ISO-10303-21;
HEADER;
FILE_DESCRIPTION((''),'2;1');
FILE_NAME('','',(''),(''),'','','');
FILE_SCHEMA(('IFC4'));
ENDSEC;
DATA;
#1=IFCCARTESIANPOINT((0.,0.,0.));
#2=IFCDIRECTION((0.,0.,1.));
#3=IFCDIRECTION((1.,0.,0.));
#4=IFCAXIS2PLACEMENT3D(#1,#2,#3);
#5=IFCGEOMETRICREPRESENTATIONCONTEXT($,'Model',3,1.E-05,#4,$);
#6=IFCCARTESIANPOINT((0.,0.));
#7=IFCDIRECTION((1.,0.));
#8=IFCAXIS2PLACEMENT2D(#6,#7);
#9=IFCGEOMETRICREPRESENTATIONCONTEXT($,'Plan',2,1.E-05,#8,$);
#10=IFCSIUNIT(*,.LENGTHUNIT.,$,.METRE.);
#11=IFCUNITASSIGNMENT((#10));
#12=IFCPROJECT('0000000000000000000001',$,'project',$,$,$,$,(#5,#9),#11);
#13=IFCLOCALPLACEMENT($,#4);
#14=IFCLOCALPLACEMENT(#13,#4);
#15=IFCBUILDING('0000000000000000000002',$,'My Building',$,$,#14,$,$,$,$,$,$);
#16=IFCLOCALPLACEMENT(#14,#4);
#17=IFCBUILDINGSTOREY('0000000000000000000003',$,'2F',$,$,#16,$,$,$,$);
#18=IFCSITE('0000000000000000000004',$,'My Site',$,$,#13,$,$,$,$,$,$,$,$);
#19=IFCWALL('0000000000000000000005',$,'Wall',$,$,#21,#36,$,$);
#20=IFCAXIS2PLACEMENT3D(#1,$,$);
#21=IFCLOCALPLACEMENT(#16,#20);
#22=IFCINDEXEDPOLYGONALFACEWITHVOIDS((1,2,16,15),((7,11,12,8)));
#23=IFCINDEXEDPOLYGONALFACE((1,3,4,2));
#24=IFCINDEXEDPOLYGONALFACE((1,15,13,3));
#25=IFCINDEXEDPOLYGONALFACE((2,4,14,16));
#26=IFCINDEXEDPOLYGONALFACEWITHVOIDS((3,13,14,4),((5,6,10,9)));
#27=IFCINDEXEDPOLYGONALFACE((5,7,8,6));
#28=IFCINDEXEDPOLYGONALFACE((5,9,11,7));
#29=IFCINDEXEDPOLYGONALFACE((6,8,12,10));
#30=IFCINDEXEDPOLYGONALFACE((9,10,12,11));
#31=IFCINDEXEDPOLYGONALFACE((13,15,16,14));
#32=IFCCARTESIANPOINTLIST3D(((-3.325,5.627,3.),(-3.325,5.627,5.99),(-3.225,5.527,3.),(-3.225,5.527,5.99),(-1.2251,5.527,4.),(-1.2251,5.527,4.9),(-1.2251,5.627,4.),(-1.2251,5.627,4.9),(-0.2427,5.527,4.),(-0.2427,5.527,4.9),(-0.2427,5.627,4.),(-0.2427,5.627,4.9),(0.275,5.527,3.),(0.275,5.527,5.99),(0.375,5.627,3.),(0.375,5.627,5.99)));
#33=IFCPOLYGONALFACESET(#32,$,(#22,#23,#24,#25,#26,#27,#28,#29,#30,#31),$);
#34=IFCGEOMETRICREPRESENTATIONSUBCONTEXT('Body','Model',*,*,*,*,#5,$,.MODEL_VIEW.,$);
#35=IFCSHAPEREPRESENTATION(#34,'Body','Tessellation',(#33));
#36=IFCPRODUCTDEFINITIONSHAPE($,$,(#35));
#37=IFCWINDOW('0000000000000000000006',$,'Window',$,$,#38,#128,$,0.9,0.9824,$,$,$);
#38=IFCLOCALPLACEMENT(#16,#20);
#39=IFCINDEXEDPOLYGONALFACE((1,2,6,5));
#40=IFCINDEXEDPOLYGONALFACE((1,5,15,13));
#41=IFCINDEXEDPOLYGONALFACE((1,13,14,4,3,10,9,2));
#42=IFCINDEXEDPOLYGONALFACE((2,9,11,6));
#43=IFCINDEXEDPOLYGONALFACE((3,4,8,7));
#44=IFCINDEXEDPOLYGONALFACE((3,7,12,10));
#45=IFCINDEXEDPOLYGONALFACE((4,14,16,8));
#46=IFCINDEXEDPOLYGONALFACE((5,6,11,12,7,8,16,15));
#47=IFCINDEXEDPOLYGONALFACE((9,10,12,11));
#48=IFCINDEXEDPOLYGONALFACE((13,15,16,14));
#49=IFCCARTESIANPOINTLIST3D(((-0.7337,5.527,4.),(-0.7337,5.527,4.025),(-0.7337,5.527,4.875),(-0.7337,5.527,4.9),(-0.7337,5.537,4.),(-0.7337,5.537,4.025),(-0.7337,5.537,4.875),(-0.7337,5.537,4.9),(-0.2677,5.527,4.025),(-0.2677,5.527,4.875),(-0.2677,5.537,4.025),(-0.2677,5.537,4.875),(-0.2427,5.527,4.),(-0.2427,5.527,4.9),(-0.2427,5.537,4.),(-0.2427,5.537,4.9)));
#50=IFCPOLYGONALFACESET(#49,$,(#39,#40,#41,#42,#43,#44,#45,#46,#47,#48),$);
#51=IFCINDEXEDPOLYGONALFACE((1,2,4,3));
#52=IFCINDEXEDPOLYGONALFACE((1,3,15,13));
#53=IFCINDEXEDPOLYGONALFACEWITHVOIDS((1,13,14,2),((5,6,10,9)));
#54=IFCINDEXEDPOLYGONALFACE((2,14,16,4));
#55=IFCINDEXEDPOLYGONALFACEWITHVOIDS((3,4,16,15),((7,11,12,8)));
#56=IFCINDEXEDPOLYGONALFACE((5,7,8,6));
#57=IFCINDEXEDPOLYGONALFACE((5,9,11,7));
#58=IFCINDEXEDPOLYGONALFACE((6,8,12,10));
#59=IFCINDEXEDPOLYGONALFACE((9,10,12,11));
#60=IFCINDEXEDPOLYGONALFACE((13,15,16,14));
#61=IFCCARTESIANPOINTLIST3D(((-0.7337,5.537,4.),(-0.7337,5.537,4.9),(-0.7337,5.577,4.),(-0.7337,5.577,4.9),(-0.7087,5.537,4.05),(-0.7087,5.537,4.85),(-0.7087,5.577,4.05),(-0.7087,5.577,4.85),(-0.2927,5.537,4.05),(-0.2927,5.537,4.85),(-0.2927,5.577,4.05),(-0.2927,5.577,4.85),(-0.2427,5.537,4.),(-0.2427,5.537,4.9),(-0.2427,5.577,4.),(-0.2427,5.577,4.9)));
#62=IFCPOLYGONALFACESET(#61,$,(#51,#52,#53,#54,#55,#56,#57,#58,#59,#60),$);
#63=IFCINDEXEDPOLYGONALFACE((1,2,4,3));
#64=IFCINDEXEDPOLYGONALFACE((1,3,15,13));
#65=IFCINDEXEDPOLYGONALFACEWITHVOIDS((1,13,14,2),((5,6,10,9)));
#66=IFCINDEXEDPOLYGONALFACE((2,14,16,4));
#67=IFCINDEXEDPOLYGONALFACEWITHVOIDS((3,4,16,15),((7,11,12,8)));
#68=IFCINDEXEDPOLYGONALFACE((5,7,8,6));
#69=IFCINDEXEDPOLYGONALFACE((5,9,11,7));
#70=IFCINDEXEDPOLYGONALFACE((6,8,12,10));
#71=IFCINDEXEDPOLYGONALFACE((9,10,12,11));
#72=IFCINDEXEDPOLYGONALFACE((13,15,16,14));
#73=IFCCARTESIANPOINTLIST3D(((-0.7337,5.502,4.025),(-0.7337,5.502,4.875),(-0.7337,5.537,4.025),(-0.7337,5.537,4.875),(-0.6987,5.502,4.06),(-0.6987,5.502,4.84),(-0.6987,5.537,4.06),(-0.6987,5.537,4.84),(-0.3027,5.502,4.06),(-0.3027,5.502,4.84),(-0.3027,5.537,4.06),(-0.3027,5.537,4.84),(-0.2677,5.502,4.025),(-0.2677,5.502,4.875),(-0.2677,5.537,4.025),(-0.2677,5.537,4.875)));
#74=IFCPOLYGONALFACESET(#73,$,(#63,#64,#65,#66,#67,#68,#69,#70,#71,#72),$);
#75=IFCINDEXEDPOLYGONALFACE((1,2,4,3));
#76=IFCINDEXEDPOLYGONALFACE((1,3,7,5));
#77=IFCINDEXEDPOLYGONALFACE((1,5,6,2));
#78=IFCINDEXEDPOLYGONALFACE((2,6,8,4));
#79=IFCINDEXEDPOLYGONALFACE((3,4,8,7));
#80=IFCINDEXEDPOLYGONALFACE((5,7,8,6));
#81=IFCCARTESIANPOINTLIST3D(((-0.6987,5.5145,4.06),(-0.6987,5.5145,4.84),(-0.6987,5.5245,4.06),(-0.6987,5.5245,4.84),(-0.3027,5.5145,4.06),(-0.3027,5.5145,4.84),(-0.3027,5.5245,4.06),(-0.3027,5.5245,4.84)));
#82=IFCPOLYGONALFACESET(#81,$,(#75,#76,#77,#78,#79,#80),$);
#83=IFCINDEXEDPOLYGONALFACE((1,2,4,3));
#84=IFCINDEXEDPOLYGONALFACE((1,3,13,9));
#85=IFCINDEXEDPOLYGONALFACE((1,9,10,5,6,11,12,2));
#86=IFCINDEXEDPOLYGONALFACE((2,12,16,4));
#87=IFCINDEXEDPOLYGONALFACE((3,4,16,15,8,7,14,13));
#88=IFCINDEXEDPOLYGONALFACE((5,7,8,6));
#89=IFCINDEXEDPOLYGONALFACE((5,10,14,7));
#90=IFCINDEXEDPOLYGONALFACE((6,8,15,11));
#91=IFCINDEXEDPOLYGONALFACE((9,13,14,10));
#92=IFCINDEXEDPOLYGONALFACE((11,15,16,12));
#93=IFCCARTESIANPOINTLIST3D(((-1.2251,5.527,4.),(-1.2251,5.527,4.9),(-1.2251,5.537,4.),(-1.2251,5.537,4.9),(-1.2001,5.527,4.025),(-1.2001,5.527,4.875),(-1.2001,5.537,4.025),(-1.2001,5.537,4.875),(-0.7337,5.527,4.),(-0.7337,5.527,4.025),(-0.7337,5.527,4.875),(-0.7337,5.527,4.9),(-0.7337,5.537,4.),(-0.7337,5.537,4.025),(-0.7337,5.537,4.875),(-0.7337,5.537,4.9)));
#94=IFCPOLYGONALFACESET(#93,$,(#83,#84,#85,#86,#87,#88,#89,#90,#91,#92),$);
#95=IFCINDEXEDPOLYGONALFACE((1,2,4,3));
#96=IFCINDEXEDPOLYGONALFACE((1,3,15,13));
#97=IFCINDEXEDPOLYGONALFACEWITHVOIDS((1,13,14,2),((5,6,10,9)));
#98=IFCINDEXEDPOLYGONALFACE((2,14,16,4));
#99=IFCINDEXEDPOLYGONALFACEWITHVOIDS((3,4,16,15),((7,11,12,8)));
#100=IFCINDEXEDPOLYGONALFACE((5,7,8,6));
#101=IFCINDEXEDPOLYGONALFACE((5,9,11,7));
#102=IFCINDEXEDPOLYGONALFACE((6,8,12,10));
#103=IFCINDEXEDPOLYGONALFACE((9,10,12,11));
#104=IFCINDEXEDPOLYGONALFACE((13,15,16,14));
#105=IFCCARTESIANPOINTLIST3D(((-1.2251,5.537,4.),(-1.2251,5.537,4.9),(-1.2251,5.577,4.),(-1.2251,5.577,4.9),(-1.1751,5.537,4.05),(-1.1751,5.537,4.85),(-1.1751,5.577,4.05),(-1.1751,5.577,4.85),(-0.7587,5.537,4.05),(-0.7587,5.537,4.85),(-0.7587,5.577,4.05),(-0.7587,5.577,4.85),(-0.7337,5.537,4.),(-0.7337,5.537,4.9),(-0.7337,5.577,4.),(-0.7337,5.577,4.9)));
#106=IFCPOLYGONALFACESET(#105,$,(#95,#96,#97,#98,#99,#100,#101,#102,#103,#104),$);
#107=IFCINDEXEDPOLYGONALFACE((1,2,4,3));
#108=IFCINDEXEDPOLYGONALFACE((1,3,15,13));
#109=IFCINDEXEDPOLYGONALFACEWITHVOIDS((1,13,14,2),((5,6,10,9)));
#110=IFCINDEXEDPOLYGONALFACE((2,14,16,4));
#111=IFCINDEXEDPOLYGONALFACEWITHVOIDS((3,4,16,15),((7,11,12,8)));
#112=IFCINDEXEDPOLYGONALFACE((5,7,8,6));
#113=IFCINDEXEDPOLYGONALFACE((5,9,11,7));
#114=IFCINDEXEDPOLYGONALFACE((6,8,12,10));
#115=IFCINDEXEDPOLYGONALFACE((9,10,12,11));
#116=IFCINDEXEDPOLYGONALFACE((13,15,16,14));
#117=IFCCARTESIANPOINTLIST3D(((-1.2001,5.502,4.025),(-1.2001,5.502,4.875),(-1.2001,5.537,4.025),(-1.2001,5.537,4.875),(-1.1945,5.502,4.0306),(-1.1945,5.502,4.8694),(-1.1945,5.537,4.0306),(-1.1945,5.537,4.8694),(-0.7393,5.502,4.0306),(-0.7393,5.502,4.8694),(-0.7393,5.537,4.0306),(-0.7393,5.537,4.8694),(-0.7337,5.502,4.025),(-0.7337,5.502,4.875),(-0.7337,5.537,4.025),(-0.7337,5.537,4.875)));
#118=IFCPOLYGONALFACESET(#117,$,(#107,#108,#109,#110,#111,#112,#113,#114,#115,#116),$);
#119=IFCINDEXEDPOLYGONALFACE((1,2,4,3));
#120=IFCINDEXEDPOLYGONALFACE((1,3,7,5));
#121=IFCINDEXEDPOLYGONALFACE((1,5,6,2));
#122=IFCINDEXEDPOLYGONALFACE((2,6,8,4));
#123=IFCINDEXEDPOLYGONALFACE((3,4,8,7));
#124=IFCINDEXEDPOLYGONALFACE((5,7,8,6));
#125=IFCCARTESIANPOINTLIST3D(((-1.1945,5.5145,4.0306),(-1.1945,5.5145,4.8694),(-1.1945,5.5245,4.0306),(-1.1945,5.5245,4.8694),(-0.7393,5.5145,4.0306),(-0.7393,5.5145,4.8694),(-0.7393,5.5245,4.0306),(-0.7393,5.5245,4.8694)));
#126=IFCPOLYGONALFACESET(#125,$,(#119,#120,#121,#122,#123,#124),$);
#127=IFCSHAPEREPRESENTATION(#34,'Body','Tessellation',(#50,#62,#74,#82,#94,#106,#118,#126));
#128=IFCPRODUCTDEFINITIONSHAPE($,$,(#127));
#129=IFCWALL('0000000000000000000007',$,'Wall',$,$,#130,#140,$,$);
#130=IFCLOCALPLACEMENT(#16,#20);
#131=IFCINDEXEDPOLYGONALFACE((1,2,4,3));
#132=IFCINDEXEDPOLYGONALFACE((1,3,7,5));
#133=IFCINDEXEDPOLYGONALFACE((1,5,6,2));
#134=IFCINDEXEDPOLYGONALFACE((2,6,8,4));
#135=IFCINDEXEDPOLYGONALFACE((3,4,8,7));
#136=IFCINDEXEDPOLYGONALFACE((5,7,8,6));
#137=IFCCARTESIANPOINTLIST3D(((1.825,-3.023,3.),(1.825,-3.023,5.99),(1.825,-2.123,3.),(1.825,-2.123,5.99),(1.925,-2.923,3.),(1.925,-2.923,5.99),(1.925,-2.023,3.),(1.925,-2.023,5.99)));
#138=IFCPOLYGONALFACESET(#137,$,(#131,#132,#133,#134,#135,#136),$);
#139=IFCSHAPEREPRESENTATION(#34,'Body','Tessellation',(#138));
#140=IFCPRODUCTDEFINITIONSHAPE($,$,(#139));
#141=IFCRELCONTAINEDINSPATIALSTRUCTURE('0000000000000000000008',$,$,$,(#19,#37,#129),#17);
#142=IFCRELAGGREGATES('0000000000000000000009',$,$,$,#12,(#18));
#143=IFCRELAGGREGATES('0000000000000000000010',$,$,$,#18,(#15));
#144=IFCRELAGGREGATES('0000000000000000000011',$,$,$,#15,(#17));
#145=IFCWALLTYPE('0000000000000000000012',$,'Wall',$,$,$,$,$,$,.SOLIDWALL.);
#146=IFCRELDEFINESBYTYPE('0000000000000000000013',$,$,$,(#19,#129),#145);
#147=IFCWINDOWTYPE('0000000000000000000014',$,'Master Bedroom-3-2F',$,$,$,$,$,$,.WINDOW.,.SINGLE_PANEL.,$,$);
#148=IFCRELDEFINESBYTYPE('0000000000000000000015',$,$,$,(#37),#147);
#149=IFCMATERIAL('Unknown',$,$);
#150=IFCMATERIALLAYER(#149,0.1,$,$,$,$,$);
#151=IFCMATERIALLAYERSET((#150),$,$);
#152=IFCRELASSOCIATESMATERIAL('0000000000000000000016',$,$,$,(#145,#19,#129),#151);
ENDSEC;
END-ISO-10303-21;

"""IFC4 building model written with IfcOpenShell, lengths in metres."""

from ifc_helpers import new_model, entity, si_unit, frame, origin_with_axes, origin_2d_with_axis, place, context, subcontext, project, spatial, line, indexed_curve, outline, extrude, shape, source, transform, mapped, material, layer, layer_set, layer_usage, type_object, type_shapes, element, fill, save


model = new_model("IFC4")

# Units and contexts
model_context = context("Model", 3, precision=1e-05, world=origin_with_axes())
plan_context = context("Plan", 2, precision=1e-05, world=origin_2d_with_axis())
body_context_1 = subcontext(model_context, "Body", "Model", "MODEL_VIEW")
body_context_2 = subcontext(plan_context, "Body", "Plan", "PLAN_VIEW")
ifc_project = project(units=[si_unit("LENGTHUNIT", "METRE")], contexts=[model_context, plan_context])

# Site, building, storey
site_placement = place(None, origin_with_axes())
site = spatial("IfcSite", under=ifc_project, at=site_placement, Name="My Site")
building_placement = place(site_placement, origin_with_axes())
building = spatial("IfcBuilding", under=site, at=building_placement, Name="My Building")
storey_placement = place(building_placement, origin_with_axes())
storey = spatial("IfcBuildingStorey", under=building, at=storey_placement, Name="2F")

# Shared definitions
ifc_material = material(Name="Unknown")

# Shared definitions
ifc_layer_1 = layer(ifc_material, 0.1)
ifc_layer_set_1 = layer_set([ifc_layer_1])
wall_type = type_object("IfcWallType", Name="Wall", PredefinedType="SOLIDWALL", material=ifc_layer_set_1)

# Wall, opening, window
ifc_layer_usage_1 = layer_usage(ifc_layer_set_1, "AXIS2", "POSITIVE", 0.0)
wall_1_placement = place(storey_placement, frame((0.275, 5.627, 3.0), z_axis=(0.0, 0.0, 1.0), x_axis=(-1.0, 0.0, 0.0)))
wall_1 = element("IfcWall", 1, at=wall_1_placement, inside=storey, type_object=wall_type, material=ifc_layer_usage_1, Name="Wall", context=body_context_1, shape_type="SweptSolid", body=[
    extrude(outline(indexed_curve([(-0.1, 0.0), (0.0, 0.1), (3.5, 0.1), (3.6, 0.0)], segments=[line(1, 2, 3, 4, 1)])), origin_with_axes(), (0.0, 0.0, 1.0), 2.99),
])
shared_shape_1 = source(origin_with_axes(), body_context_1, "Body", "SweptSolid", [
    extrude(outline(indexed_curve([(0.0, 0.0), (0.9824, 0.0), (0.9824, 0.9), (0.0, 0.9)], segments=[line(1, 2, 3, 4, 1)])), frame((0.0, -0.6, 0.0), z_axis=(0.0, -1.0, 0.0), x_axis=(1.0, 0.0, 0.0)), (0.0, 0.0, -1.0), 1.2),
])
opening_1_placement = place(wall_1_placement, frame((0.5177, 0.0, 1.0), z_axis=(0.0, 0.0, 1.0), x_axis=(1.0, 0.0, 0.0)))
opening_1 = element("IfcOpeningElement", 2, at=opening_1_placement, cuts=wall_1, PredefinedType="OPENING", context=body_context_1, shape_type="MappedRepresentation", body=[
    mapped(shared_shape_1, transform((0.0, 0.0, 0.0), x_axis=(1.0, 0.0, 0.0), y_axis=(0.0, 1.0, 0.0), z_axis=(0.0, 0.0, 1.0), scale=1.0)),
])
window_type_1 = type_object("IfcWindowType", Name="Master Bedroom-3-2F", PartitioningType="SINGLE_PANEL", PredefinedType="WINDOW")
shared_shape_2 = source(origin_with_axes(), body_context_1, "Body", "SweptSolid", [
    extrude(outline(indexed_curve([(0.4911, 0.0), (0.0, 0.0), (0.0, 0.9), (0.4911, 0.9), (0.4911, 0.875), (0.025, 0.875), (0.025, 0.025), (0.4911, 0.025)], segments=[line(1, 2, 3, 4, 5, 6, 7, 8, 1)])), frame((0.0, 0.09, 0.0), z_axis=(0.0, -1.0, 0.0), x_axis=(1.0, 0.0, 0.0)), (0.0, 0.0, -1.0), 0.01),
    extrude(outline(indexed_curve([(0.0, 0.0), (0.4911, 0.0), (0.4911, 0.9), (0.0, 0.9)], segments=[line(1, 2, 3, 4, 1)]), holes=[indexed_curve([(0.05, 0.05), (0.4661, 0.05), (0.4661, 0.85), (0.05, 0.85)], segments=[line(1, 2, 3, 4, 1)])]), frame((0.0, 0.05, 0.0), z_axis=(0.0, -1.0, 0.0), x_axis=(1.0, 0.0, 0.0)), (0.0, 0.0, -1.0), 0.04),
    extrude(outline(indexed_curve([(0.0, 0.0), (0.4661, 0.0), (0.4661, 0.85), (0.0, 0.85)], segments=[line(1, 2, 3, 4, 1)]), holes=[indexed_curve([(0.035, 0.035), (0.4311, 0.035), (0.4311, 0.815), (0.035, 0.815)], segments=[line(1, 2, 3, 4, 1)])]), frame((0.025, 0.09, 0.025), z_axis=(0.0, -1.0, 0.0), x_axis=(1.0, 0.0, 0.0)), (0.0, 0.0, -1.0), 0.035),
    extrude(outline(indexed_curve([(0.035, 0.035), (0.4311, 0.035), (0.4311, 0.815), (0.035, 0.815)], segments=[line(1, 2, 3, 4, 1)])), frame((0.025, 0.1025, 0.025), z_axis=(0.0, -1.0, 0.0), x_axis=(1.0, 0.0, 0.0)), (0.0, 0.0, -1.0), 0.01),
    extrude(outline(indexed_curve([(0.0, 0.9), (0.4913, 0.9), (0.4913, 0.0), (0.0, 0.0), (0.0, 0.025), (0.4663, 0.025), (0.4663, 0.875), (0.0, 0.875)], segments=[line(1, 2, 3, 4, 5, 6, 7, 8, 1)])), frame((0.4911, 0.09, 0.0), z_axis=(0.0, -1.0, 0.0), x_axis=(1.0, 0.0, 0.0)), (0.0, 0.0, -1.0), 0.01),
    extrude(outline(indexed_curve([(0.0, 0.0), (0.4913, 0.0), (0.4913, 0.9), (0.0, 0.9)], segments=[line(1, 2, 3, 4, 1)]), holes=[indexed_curve([(0.025, 0.05), (0.4413, 0.05), (0.4413, 0.85), (0.025, 0.85)], segments=[line(1, 2, 3, 4, 1)])]), frame((0.4911, 0.05, 0.0), z_axis=(0.0, -1.0, 0.0), x_axis=(1.0, 0.0, 0.0)), (0.0, 0.0, -1.0), 0.04),
    extrude(outline(indexed_curve([(0.0, 0.0), (0.4663, 0.0), (0.4663, 0.85), (0.0, 0.85)], segments=[line(1, 2, 3, 4, 1)]), holes=[indexed_curve([(0.0056, 0.0056), (0.4608, 0.0056), (0.4608, 0.8444), (0.0056, 0.8444)], segments=[line(1, 2, 3, 4, 1)])]), frame((0.4911, 0.09, 0.025), z_axis=(0.0, -1.0, 0.0), x_axis=(1.0, 0.0, 0.0)), (0.0, 0.0, -1.0), 0.035),
    extrude(outline(indexed_curve([(0.0056, 0.0056), (0.4608, 0.0056), (0.4608, 0.8444), (0.0056, 0.8444)], segments=[line(1, 2, 3, 4, 1)])), frame((0.4911, 0.1025, 0.025), z_axis=(0.0, -1.0, 0.0), x_axis=(1.0, 0.0, 0.0)), (0.0, 0.0, -1.0), 0.01),
])
shared_shape_3 = source(origin_with_axes(), body_context_2, "Body", "Curve2D", [
    entity("IfcIndexedPolyCurve", entity("IfcCartesianPointList2D", [[0.05, 0.05], [0.4661, 0.05]])),
    entity("IfcIndexedPolyCurve", entity("IfcCartesianPointList2D", [[0.0, 0.1], [0.025, 0.1], [0.025, 0.09], [0.05, 0.09], [0.05, 0.05], [0.0, 0.05]]), [entity("IfcLineIndex", [1, 2, 3, 4, 5, 6, 1])]),
    entity("IfcIndexedPolyCurve", entity("IfcCartesianPointList2D", [[0.4911, 0.1], [0.4911, 0.1], [0.4911, 0.09], [0.4661, 0.09], [0.4661, 0.05], [0.4911, 0.05]])),
    entity("IfcIndexedPolyCurve", entity("IfcCartesianPointList2D", [[0.025, 0.09], [0.06, 0.09], [0.06, 0.125], [0.025, 0.125]]), [entity("IfcLineIndex", [1, 2, 3, 4, 1])]),
    entity("IfcIndexedPolyCurve", entity("IfcCartesianPointList2D", [[0.4911, 0.09], [0.4561, 0.09], [0.4561, 0.125], [0.4911, 0.125]]), [entity("IfcLineIndex", [1, 2, 3, 4, 1])]),
    entity("IfcIndexedPolyCurve", entity("IfcCartesianPointList2D", [[0.06, 0.09], [0.4561, 0.09]])),
    entity("IfcIndexedPolyCurve", entity("IfcCartesianPointList2D", [[0.06, 0.125], [0.4561, 0.125]])),
    entity("IfcIndexedPolyCurve", entity("IfcCartesianPointList2D", [[0.06, 0.1075], [0.4561, 0.1075]])),
    entity("IfcIndexedPolyCurve", entity("IfcCartesianPointList2D", [[0.5161, 0.05], [0.9324, 0.05]])),
    entity("IfcIndexedPolyCurve", entity("IfcCartesianPointList2D", [[0.4911, 0.1], [0.4911, 0.1], [0.4911, 0.09], [0.5161, 0.09], [0.5161, 0.05], [0.4911, 0.05]])),
    entity("IfcIndexedPolyCurve", entity("IfcCartesianPointList2D", [[0.9824, 0.1], [0.9574, 0.1], [0.9574, 0.09], [0.9324, 0.09], [0.9324, 0.05], [0.9824, 0.05]]), [entity("IfcLineIndex", [1, 2, 3, 4, 5, 6, 1])]),
    entity("IfcIndexedPolyCurve", entity("IfcCartesianPointList2D", [[0.4911, 0.09], [0.4966, 0.09], [0.4966, 0.125], [0.4911, 0.125]]), [entity("IfcLineIndex", [1, 2, 3, 4, 1])]),
    entity("IfcIndexedPolyCurve", entity("IfcCartesianPointList2D", [[0.9574, 0.09], [0.9519, 0.09], [0.9519, 0.125], [0.9574, 0.125]]), [entity("IfcLineIndex", [1, 2, 3, 4, 1])]),
    entity("IfcIndexedPolyCurve", entity("IfcCartesianPointList2D", [[0.4966, 0.09], [0.9519, 0.09]])),
    entity("IfcIndexedPolyCurve", entity("IfcCartesianPointList2D", [[0.4966, 0.125], [0.9519, 0.125]])),
    entity("IfcIndexedPolyCurve", entity("IfcCartesianPointList2D", [[0.4966, 0.1075], [0.9519, 0.1075]])),
])
type_shapes(window_type_1, [shared_shape_2, shared_shape_3])
window_1_placement = place(opening_1_placement, frame((0.0, 0.0, 0.0), z_axis=(0.0, 0.0, 1.0), x_axis=(1.0, 0.0, 0.0)))
window_1 = element("IfcWindow", 3, at=window_1_placement, inside=storey, type_object=window_type_1, Name="Window", OverallHeight=0.9, OverallWidth=0.9824, shapes=[
    shape(body_context_1, "Body", "MappedRepresentation", [mapped(shared_shape_2, transform((0.0, 0.0, 0.0), x_axis=(1.0, 0.0, 0.0), y_axis=(0.0, 1.0, 0.0), z_axis=(0.0, 0.0, 1.0), scale=1.0))]),
    shape(body_context_2, "Body", "MappedRepresentation", [mapped(shared_shape_3, transform((0.0, 0.0, 0.0), x_axis=(1.0, 0.0, 0.0), y_axis=(0.0, 1.0, 0.0), z_axis=(0.0, 0.0, 1.0), scale=1.0))]),
])
fill(opening_1, window_1)

# Wall
ifc_layer_usage_2 = layer_usage(ifc_layer_set_1, "AXIS2", "POSITIVE", 0.0)
wall_2_placement = place(storey_placement, frame((1.825, -2.123, 3.0), z_axis=(0.0, 0.0, 1.0), x_axis=(0.0, -1.0, 0.0)))
element("IfcWall", 4, at=wall_2_placement, inside=storey, type_object=wall_type, material=ifc_layer_usage_2, Name="Wall", context=body_context_1, shape_type="SweptSolid", body=[
    extrude(outline(indexed_curve([(0.0, 0.0), (-0.1, 0.1), (0.8, 0.1), (0.9, 0.0)], segments=[line(1, 2, 3, 4, 1)])), origin_with_axes(), (0.0, 0.0, 1.0), 2.99),
])

save(model, "model.ifc")
